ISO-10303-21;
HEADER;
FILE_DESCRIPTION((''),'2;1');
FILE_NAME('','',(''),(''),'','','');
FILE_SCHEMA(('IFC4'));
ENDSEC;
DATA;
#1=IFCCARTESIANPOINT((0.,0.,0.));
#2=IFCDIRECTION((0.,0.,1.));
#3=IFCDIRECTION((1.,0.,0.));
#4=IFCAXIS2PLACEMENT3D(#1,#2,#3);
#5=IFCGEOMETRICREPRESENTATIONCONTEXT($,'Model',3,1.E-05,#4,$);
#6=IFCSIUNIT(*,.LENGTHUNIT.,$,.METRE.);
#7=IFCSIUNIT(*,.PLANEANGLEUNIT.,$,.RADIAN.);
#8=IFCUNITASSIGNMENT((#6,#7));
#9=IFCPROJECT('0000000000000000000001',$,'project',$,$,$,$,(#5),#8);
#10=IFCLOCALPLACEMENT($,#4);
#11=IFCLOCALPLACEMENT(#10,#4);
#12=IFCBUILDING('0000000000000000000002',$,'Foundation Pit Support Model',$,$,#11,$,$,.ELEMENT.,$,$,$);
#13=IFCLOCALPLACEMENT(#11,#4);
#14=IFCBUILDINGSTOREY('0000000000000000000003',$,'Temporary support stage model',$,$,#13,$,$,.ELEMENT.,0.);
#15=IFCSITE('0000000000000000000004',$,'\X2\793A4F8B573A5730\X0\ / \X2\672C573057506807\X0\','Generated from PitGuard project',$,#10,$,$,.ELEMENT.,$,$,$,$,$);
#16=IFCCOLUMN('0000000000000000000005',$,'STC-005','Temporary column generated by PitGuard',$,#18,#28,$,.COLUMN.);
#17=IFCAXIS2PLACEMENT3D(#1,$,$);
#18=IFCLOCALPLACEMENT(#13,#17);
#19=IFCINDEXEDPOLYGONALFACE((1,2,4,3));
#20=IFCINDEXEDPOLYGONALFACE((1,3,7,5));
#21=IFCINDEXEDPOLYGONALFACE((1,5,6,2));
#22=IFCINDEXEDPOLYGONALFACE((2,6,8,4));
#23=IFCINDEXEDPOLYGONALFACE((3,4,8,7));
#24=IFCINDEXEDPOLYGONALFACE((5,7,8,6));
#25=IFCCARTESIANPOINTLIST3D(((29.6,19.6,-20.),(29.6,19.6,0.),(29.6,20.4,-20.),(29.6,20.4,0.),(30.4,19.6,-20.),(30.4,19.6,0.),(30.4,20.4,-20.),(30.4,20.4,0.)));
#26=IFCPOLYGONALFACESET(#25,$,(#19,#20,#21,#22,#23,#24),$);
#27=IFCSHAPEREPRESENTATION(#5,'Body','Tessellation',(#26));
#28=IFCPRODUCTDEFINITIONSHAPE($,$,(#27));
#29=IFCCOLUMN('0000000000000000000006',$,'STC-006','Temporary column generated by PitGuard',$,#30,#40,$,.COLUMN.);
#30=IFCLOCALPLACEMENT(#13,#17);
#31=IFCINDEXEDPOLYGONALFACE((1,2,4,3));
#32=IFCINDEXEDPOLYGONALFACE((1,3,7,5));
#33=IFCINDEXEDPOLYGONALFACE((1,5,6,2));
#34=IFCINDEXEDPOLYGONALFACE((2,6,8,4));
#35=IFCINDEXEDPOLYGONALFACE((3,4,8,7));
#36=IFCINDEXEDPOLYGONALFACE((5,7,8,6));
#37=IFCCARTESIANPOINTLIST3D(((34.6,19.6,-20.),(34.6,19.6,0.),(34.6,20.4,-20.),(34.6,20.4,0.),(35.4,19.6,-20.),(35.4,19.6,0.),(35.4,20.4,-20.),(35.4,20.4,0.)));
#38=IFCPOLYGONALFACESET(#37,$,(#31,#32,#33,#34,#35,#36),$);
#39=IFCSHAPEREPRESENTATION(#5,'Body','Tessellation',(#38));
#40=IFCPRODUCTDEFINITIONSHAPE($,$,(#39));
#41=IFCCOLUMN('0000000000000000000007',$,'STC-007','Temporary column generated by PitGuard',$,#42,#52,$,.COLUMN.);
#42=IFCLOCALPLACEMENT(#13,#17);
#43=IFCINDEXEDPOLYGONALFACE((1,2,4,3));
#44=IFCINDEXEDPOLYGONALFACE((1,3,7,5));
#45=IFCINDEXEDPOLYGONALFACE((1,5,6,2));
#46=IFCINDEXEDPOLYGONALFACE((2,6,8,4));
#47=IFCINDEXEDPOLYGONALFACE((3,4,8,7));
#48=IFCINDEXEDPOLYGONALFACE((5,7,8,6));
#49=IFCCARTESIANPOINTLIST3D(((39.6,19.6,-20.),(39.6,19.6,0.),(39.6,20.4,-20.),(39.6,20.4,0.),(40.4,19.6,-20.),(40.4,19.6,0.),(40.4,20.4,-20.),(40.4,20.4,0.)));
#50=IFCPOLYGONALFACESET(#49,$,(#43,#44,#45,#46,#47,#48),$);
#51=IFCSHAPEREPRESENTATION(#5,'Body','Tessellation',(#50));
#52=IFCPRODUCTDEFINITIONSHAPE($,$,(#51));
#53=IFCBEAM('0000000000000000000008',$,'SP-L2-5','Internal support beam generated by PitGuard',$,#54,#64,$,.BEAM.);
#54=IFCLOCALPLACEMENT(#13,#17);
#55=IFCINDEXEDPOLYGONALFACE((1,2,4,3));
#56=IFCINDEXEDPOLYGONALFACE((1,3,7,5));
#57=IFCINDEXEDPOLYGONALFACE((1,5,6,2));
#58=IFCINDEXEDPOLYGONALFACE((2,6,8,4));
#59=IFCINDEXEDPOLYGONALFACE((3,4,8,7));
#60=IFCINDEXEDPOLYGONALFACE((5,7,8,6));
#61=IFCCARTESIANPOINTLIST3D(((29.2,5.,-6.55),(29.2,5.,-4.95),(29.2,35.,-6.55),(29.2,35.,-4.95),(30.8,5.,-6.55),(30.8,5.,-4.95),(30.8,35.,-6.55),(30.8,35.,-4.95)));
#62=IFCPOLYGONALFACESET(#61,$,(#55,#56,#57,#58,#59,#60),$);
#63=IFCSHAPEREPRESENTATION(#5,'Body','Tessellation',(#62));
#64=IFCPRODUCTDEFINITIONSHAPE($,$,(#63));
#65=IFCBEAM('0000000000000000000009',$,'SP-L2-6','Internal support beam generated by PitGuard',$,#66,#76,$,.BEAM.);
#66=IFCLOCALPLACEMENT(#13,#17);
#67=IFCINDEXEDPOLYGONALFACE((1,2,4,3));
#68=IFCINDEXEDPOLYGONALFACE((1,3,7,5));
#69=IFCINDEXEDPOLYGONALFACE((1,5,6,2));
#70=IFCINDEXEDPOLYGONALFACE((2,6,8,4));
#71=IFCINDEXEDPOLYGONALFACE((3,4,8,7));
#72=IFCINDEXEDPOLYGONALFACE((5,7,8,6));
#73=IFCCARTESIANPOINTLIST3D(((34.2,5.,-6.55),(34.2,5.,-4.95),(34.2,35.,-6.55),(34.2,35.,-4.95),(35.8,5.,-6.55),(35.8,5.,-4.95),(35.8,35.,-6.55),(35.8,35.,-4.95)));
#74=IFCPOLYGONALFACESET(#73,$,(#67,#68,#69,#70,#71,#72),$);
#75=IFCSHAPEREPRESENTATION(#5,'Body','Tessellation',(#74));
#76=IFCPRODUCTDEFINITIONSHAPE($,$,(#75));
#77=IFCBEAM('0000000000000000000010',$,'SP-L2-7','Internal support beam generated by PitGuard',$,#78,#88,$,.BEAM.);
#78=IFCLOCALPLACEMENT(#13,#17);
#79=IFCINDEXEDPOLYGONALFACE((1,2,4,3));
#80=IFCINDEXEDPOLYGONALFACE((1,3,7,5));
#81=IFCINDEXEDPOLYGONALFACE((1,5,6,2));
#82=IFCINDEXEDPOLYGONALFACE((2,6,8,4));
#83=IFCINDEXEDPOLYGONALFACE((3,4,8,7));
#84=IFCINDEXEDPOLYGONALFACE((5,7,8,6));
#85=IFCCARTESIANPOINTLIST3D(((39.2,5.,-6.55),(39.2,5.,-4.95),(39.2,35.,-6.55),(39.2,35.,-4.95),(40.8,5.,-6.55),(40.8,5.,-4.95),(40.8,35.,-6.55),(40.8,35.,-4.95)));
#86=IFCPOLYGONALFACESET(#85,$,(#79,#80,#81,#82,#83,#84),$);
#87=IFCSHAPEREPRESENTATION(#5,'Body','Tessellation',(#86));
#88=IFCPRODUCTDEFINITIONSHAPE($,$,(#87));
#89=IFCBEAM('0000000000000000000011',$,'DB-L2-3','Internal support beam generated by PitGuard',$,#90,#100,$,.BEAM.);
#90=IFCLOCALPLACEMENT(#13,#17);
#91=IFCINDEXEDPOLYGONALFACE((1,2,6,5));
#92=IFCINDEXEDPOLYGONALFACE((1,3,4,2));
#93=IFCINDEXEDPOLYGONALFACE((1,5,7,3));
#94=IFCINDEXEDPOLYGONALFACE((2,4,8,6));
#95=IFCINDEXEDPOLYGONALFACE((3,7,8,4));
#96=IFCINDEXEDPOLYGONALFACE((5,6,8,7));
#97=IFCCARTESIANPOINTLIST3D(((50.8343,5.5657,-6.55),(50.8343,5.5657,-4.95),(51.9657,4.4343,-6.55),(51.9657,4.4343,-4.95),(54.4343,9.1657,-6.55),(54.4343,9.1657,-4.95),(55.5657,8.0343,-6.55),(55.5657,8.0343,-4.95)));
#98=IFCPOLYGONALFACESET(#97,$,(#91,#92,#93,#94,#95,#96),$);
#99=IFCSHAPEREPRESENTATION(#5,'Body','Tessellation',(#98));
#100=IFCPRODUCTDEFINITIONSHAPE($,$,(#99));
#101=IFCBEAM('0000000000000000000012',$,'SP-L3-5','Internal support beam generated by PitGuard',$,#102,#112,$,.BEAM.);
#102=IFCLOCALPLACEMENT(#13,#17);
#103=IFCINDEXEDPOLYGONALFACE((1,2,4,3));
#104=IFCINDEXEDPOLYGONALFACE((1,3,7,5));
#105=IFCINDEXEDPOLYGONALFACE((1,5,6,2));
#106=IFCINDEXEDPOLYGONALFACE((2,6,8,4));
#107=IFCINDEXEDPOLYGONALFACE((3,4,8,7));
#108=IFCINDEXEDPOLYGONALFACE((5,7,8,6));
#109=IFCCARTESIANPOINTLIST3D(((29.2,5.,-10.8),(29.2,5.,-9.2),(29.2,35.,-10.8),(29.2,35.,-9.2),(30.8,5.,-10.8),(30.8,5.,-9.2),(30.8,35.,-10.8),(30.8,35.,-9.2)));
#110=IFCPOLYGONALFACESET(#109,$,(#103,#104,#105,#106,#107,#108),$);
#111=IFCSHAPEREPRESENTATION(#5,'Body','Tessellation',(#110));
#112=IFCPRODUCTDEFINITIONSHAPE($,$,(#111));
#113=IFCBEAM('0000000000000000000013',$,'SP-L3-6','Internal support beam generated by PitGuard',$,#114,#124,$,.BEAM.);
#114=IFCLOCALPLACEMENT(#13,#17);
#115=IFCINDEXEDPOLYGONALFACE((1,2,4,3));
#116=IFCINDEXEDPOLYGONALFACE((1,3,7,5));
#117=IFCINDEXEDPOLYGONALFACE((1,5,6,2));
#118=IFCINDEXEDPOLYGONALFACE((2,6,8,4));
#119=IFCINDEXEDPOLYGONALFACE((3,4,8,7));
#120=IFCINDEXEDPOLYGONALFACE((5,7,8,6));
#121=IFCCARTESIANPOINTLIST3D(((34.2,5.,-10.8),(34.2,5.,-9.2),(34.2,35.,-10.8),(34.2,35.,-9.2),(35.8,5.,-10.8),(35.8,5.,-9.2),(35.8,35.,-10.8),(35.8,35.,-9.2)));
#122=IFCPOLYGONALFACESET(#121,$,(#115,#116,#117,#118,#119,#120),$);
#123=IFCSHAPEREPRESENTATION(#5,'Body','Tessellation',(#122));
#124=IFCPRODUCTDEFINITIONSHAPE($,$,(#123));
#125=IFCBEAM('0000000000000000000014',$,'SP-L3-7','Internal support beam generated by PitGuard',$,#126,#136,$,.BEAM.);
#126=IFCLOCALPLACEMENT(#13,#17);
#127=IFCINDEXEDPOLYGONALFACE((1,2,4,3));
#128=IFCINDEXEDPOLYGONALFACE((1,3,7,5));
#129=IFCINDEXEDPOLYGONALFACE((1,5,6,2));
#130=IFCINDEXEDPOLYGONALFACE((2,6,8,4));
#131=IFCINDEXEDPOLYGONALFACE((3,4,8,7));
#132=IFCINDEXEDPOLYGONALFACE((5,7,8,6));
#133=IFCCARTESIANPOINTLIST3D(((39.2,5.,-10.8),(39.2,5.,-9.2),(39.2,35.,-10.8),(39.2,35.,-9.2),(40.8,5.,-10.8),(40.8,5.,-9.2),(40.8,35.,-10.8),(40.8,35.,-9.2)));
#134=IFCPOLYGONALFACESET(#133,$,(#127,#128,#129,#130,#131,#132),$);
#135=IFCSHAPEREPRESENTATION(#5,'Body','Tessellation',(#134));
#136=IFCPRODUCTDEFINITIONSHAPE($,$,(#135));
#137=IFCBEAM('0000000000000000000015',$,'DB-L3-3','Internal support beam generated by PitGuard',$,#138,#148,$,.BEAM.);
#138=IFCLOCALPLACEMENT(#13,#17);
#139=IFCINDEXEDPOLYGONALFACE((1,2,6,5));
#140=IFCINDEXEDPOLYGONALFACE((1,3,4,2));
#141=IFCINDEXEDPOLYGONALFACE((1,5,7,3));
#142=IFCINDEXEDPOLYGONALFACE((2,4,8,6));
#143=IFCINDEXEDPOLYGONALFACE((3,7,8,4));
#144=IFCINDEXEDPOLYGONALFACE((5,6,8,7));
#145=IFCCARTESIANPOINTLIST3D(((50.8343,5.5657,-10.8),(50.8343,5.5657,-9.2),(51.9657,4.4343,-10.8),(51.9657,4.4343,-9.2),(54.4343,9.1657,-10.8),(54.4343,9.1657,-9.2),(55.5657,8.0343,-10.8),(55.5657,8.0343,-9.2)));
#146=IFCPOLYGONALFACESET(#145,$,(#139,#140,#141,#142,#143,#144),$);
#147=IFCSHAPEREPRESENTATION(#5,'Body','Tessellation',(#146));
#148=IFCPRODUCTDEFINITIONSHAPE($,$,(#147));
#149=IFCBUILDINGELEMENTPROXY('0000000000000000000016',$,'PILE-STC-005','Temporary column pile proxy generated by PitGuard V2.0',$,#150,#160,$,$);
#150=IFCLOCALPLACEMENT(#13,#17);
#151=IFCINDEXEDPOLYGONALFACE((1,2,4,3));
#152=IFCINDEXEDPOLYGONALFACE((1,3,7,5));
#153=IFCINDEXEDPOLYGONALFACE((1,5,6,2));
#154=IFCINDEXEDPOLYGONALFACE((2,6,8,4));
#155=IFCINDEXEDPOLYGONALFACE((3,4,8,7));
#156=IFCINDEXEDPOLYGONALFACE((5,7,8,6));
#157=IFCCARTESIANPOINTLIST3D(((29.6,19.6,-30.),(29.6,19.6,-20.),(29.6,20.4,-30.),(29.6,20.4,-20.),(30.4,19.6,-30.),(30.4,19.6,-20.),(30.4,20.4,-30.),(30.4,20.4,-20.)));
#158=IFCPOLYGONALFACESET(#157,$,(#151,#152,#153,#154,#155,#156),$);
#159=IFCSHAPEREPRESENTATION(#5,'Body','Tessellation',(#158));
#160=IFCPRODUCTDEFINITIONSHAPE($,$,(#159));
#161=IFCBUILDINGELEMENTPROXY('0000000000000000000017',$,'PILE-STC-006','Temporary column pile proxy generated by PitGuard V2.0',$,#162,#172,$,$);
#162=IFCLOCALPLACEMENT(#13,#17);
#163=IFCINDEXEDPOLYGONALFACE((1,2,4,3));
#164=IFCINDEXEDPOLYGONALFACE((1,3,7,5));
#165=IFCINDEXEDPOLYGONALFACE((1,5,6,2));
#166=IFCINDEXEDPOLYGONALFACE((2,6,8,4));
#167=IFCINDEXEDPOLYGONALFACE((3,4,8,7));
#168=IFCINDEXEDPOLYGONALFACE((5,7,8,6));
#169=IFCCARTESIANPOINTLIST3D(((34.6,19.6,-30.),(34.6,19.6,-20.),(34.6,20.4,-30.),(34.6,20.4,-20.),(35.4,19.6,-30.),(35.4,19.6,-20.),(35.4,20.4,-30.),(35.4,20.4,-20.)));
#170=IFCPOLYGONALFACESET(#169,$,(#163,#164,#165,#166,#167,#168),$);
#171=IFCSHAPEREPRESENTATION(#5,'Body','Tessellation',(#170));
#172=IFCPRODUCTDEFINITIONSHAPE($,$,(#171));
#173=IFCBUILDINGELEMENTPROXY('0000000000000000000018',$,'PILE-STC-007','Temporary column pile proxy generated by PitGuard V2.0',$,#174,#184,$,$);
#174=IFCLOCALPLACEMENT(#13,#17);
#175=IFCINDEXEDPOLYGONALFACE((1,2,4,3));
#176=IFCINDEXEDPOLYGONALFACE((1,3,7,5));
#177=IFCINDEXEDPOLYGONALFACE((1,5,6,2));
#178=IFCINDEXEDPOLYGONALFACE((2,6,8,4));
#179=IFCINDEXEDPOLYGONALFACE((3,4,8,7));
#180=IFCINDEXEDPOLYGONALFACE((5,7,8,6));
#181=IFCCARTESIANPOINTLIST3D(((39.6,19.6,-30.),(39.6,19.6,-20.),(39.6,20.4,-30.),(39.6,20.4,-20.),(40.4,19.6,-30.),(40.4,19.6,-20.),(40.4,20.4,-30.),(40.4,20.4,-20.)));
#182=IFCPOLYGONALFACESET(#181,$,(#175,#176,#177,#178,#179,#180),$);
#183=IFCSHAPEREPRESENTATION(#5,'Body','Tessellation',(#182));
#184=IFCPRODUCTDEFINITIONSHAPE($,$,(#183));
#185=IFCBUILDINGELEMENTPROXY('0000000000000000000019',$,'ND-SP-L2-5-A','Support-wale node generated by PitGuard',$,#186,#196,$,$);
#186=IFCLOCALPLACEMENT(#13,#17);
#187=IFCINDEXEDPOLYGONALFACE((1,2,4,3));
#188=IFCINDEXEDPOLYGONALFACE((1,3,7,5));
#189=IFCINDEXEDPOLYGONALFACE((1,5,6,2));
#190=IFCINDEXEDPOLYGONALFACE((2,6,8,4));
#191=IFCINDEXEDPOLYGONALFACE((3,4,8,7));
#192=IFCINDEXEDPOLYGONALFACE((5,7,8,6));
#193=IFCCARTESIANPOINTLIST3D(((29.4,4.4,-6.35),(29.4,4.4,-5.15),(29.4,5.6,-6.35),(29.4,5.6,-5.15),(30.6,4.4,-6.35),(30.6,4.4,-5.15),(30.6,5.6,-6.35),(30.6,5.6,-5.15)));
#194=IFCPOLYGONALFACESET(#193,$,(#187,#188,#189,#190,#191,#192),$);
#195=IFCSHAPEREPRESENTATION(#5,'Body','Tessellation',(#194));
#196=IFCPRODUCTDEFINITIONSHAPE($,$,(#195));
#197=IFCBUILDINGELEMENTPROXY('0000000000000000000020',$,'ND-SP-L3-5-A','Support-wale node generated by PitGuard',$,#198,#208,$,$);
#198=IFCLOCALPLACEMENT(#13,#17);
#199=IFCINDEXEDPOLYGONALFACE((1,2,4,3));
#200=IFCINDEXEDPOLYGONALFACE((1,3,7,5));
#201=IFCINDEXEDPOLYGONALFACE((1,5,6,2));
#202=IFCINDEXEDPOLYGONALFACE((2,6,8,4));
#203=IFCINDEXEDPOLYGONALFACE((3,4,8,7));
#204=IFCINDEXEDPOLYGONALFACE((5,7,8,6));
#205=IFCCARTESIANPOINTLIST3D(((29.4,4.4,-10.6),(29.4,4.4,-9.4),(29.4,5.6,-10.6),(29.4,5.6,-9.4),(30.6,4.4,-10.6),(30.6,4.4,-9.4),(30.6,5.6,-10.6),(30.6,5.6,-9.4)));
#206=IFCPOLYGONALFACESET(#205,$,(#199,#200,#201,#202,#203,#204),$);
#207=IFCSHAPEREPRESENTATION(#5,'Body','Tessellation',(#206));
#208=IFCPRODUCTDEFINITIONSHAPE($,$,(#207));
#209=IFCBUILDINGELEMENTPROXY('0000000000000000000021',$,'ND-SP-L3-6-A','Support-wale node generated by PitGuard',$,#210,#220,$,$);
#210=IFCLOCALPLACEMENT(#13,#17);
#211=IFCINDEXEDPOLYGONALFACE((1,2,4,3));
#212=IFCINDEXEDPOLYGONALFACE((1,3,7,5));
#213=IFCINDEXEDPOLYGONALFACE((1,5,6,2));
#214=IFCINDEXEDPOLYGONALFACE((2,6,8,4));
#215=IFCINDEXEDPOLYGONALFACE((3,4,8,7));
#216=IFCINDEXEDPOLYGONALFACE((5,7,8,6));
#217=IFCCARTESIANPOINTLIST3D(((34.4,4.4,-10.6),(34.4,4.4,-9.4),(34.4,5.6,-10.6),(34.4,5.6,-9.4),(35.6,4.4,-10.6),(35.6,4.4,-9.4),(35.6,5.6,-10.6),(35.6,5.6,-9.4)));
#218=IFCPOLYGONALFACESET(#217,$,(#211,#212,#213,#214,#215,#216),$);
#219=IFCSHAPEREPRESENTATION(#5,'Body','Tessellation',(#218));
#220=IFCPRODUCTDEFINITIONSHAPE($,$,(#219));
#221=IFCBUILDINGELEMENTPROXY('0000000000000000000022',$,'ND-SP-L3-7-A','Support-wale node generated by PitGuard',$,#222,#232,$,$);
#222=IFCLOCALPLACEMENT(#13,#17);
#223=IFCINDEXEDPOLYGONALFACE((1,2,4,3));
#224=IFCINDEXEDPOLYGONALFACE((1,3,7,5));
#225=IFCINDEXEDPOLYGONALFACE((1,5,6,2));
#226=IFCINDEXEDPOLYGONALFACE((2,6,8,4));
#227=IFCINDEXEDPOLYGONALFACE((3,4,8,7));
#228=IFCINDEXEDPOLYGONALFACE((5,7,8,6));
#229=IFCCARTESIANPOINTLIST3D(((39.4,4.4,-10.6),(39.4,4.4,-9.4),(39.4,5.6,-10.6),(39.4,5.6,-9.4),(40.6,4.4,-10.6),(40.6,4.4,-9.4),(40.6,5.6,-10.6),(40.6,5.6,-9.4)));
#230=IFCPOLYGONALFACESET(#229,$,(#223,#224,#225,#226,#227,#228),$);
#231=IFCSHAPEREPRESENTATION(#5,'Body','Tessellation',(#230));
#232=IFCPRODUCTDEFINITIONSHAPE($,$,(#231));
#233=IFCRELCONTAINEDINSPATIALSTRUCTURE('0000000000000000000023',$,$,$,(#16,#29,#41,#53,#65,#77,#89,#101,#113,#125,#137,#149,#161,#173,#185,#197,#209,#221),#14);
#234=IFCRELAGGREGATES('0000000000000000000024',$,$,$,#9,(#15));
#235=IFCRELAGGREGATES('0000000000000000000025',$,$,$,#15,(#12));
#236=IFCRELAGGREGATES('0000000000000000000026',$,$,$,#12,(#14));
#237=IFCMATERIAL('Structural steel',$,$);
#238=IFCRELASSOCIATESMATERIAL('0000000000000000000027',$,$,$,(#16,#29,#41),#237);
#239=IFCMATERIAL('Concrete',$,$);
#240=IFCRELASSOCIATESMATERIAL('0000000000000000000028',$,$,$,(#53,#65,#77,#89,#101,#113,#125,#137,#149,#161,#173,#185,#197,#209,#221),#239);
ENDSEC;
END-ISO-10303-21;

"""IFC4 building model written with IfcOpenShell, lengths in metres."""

from ifc_helpers import new_model, si_unit, frame, origin_with_axes, origin_2d, place, context, project, spatial, rectangle, extrude, material, element, save


model = new_model("IFC4")

# Units and contexts
model_context = context("Model", 3, precision=1e-05, world=origin_with_axes())
ifc_project = project(units=[si_unit("LENGTHUNIT", "METRE"), si_unit("PLANEANGLEUNIT", "RADIAN")], contexts=[model_context])

# Site, building, storey
site_placement = place(None, origin_with_axes())
site = spatial("IfcSite", under=ifc_project, at=site_placement, Name="示例场地 / 本地坐标", Description="Generated from PitGuard project", CompositionType="ELEMENT")
building_placement = place(site_placement, origin_with_axes())
building = spatial("IfcBuilding", under=site, at=building_placement, Name="Foundation Pit Support Model", CompositionType="ELEMENT")
storey_placement = place(building_placement, origin_with_axes())
storey = spatial("IfcBuildingStorey", under=building, at=storey_placement, Name="Temporary support stage model", CompositionType="ELEMENT", Elevation=0.0)

# Columns
ifc_material_1 = material(Name="Structural steel")
for number, where, z_axis, x_axis, name in (
    (1, (30.0, 20.0, -20.0), (0.0, 0.0, 1.0), (1.0, 0.0, 0.0), "STC-005"),
    (2, (35.0, 20.0, -20.0), (0.0, 0.0, 1.0), (1.0, 0.0, 0.0), "STC-006"),
    (3, (40.0, 20.0, -20.0), (0.0, 0.0, 1.0), (1.0, 0.0, 0.0), "STC-007"),
):
    element("IfcColumn", number, at=place(storey_placement, frame(where, z_axis=z_axis, x_axis=x_axis)), inside=storey, material=ifc_material_1, Name=name, Description="Temporary column generated by PitGuard", PredefinedType="COLUMN", context=model_context, shape_type="SweptSolid", body=[
        extrude(rectangle(XDim=0.8, YDim=0.8, at=origin_2d()), origin_with_axes(), (0.0, 0.0, 1.0), 20.0),
    ])

# Beams
ifc_material_2 = material(Name="Concrete")
for number, where, z_axis, x_axis, name in (
    (4, (30.0, 20.0, -6.55), (0.0, 0.0, 1.0), (0.0, 1.0, 0.0), "SP-L2-5"),
    (5, (35.0, 20.0, -6.55), (0.0, 0.0, 1.0), (0.0, 1.0, 0.0), "SP-L2-6"),
    (6, (40.0, 20.0, -6.55), (0.0, 0.0, 1.0), (0.0, 1.0, 0.0), "SP-L2-7"),
):
    element("IfcBeam", number, at=place(storey_placement, frame(where, z_axis=z_axis, x_axis=x_axis)), inside=storey, material=ifc_material_2, Name=name, Description="Internal support beam generated by PitGuard", PredefinedType="BEAM", context=model_context, shape_type="SweptSolid", body=[
        extrude(rectangle(XDim=30.0, YDim=1.6, at=origin_2d()), origin_with_axes(), (0.0, 0.0, 1.0), 1.6),
    ])
beam_1_placement = place(storey_placement, frame((53.2, 6.8, -6.55), z_axis=(0.0, 0.0, 1.0), x_axis=(0.707107, 0.707107, 0.0)))
element("IfcBeam", 7, at=beam_1_placement, inside=storey, material=ifc_material_2, Name="DB-L2-3", Description="Internal support beam generated by PitGuard", PredefinedType="BEAM", context=model_context, shape_type="SweptSolid", body=[
    extrude(rectangle(XDim=5.0912, YDim=1.6, at=origin_2d()), origin_with_axes(), (0.0, 0.0, 1.0), 1.6),
])
for number, where, z_axis, x_axis, name in (
    (8, (30.0, 20.0, -10.8), (0.0, 0.0, 1.0), (0.0, 1.0, 0.0), "SP-L3-5"),
    (9, (35.0, 20.0, -10.8), (0.0, 0.0, 1.0), (0.0, 1.0, 0.0), "SP-L3-6"),
    (10, (40.0, 20.0, -10.8), (0.0, 0.0, 1.0), (0.0, 1.0, 0.0), "SP-L3-7"),
):
    element("IfcBeam", number, at=place(storey_placement, frame(where, z_axis=z_axis, x_axis=x_axis)), inside=storey, material=ifc_material_2, Name=name, Description="Internal support beam generated by PitGuard", PredefinedType="BEAM", context=model_context, shape_type="SweptSolid", body=[
        extrude(rectangle(XDim=30.0, YDim=1.6, at=origin_2d()), origin_with_axes(), (0.0, 0.0, 1.0), 1.6),
    ])
beam_2_placement = place(storey_placement, frame((53.2, 6.8, -10.8), z_axis=(0.0, 0.0, 1.0), x_axis=(0.707107, 0.707107, 0.0)))
element("IfcBeam", 11, at=beam_2_placement, inside=storey, material=ifc_material_2, Name="DB-L3-3", Description="Internal support beam generated by PitGuard", PredefinedType="BEAM", context=model_context, shape_type="SweptSolid", body=[
    extrude(rectangle(XDim=5.0912, YDim=1.6, at=origin_2d()), origin_with_axes(), (0.0, 0.0, 1.0), 1.6),
])

# Building element proxies
for number, where, z_axis, x_axis, name in (
    (12, (30.0, 20.0, -30.0), (0.0, 0.0, 1.0), (1.0, 0.0, 0.0), "PILE-STC-005"),
    (13, (35.0, 20.0, -30.0), (0.0, 0.0, 1.0), (1.0, 0.0, 0.0), "PILE-STC-006"),
    (14, (40.0, 20.0, -30.0), (0.0, 0.0, 1.0), (1.0, 0.0, 0.0), "PILE-STC-007"),
):
    element("IfcBuildingElementProxy", number, at=place(storey_placement, frame(where, z_axis=z_axis, x_axis=x_axis)), inside=storey, material=ifc_material_2, Name=name, Description="Temporary column pile proxy generated by PitGuard V2.0", context=model_context, shape_type="SweptSolid", body=[
        extrude(rectangle(XDim=0.8, YDim=0.8, at=origin_2d()), origin_with_axes(), (0.0, 0.0, 1.0), 10.0),
    ])
for number, where, z_axis, x_axis, name in (
    (15, (30.0, 5.0, -6.35), (0.0, 0.0, 1.0), (1.0, 0.0, 0.0), "ND-SP-L2-5-A"),
    (16, (30.0, 5.0, -10.6), (0.0, 0.0, 1.0), (1.0, 0.0, 0.0), "ND-SP-L3-5-A"),
    (17, (35.0, 5.0, -10.6), (0.0, 0.0, 1.0), (1.0, 0.0, 0.0), "ND-SP-L3-6-A"),
    (18, (40.0, 5.0, -10.6), (0.0, 0.0, 1.0), (1.0, 0.0, 0.0), "ND-SP-L3-7-A"),
):
    element("IfcBuildingElementProxy", number, at=place(storey_placement, frame(where, z_axis=z_axis, x_axis=x_axis)), inside=storey, material=ifc_material_2, Name=name, Description="Support-wale node generated by PitGuard", context=model_context, shape_type="SweptSolid", body=[
        extrude(rectangle(XDim=1.2, YDim=1.2, at=origin_2d()), origin_with_axes(), (0.0, 0.0, 1.0), 1.2),
    ])

save(model, "model.ifc")
